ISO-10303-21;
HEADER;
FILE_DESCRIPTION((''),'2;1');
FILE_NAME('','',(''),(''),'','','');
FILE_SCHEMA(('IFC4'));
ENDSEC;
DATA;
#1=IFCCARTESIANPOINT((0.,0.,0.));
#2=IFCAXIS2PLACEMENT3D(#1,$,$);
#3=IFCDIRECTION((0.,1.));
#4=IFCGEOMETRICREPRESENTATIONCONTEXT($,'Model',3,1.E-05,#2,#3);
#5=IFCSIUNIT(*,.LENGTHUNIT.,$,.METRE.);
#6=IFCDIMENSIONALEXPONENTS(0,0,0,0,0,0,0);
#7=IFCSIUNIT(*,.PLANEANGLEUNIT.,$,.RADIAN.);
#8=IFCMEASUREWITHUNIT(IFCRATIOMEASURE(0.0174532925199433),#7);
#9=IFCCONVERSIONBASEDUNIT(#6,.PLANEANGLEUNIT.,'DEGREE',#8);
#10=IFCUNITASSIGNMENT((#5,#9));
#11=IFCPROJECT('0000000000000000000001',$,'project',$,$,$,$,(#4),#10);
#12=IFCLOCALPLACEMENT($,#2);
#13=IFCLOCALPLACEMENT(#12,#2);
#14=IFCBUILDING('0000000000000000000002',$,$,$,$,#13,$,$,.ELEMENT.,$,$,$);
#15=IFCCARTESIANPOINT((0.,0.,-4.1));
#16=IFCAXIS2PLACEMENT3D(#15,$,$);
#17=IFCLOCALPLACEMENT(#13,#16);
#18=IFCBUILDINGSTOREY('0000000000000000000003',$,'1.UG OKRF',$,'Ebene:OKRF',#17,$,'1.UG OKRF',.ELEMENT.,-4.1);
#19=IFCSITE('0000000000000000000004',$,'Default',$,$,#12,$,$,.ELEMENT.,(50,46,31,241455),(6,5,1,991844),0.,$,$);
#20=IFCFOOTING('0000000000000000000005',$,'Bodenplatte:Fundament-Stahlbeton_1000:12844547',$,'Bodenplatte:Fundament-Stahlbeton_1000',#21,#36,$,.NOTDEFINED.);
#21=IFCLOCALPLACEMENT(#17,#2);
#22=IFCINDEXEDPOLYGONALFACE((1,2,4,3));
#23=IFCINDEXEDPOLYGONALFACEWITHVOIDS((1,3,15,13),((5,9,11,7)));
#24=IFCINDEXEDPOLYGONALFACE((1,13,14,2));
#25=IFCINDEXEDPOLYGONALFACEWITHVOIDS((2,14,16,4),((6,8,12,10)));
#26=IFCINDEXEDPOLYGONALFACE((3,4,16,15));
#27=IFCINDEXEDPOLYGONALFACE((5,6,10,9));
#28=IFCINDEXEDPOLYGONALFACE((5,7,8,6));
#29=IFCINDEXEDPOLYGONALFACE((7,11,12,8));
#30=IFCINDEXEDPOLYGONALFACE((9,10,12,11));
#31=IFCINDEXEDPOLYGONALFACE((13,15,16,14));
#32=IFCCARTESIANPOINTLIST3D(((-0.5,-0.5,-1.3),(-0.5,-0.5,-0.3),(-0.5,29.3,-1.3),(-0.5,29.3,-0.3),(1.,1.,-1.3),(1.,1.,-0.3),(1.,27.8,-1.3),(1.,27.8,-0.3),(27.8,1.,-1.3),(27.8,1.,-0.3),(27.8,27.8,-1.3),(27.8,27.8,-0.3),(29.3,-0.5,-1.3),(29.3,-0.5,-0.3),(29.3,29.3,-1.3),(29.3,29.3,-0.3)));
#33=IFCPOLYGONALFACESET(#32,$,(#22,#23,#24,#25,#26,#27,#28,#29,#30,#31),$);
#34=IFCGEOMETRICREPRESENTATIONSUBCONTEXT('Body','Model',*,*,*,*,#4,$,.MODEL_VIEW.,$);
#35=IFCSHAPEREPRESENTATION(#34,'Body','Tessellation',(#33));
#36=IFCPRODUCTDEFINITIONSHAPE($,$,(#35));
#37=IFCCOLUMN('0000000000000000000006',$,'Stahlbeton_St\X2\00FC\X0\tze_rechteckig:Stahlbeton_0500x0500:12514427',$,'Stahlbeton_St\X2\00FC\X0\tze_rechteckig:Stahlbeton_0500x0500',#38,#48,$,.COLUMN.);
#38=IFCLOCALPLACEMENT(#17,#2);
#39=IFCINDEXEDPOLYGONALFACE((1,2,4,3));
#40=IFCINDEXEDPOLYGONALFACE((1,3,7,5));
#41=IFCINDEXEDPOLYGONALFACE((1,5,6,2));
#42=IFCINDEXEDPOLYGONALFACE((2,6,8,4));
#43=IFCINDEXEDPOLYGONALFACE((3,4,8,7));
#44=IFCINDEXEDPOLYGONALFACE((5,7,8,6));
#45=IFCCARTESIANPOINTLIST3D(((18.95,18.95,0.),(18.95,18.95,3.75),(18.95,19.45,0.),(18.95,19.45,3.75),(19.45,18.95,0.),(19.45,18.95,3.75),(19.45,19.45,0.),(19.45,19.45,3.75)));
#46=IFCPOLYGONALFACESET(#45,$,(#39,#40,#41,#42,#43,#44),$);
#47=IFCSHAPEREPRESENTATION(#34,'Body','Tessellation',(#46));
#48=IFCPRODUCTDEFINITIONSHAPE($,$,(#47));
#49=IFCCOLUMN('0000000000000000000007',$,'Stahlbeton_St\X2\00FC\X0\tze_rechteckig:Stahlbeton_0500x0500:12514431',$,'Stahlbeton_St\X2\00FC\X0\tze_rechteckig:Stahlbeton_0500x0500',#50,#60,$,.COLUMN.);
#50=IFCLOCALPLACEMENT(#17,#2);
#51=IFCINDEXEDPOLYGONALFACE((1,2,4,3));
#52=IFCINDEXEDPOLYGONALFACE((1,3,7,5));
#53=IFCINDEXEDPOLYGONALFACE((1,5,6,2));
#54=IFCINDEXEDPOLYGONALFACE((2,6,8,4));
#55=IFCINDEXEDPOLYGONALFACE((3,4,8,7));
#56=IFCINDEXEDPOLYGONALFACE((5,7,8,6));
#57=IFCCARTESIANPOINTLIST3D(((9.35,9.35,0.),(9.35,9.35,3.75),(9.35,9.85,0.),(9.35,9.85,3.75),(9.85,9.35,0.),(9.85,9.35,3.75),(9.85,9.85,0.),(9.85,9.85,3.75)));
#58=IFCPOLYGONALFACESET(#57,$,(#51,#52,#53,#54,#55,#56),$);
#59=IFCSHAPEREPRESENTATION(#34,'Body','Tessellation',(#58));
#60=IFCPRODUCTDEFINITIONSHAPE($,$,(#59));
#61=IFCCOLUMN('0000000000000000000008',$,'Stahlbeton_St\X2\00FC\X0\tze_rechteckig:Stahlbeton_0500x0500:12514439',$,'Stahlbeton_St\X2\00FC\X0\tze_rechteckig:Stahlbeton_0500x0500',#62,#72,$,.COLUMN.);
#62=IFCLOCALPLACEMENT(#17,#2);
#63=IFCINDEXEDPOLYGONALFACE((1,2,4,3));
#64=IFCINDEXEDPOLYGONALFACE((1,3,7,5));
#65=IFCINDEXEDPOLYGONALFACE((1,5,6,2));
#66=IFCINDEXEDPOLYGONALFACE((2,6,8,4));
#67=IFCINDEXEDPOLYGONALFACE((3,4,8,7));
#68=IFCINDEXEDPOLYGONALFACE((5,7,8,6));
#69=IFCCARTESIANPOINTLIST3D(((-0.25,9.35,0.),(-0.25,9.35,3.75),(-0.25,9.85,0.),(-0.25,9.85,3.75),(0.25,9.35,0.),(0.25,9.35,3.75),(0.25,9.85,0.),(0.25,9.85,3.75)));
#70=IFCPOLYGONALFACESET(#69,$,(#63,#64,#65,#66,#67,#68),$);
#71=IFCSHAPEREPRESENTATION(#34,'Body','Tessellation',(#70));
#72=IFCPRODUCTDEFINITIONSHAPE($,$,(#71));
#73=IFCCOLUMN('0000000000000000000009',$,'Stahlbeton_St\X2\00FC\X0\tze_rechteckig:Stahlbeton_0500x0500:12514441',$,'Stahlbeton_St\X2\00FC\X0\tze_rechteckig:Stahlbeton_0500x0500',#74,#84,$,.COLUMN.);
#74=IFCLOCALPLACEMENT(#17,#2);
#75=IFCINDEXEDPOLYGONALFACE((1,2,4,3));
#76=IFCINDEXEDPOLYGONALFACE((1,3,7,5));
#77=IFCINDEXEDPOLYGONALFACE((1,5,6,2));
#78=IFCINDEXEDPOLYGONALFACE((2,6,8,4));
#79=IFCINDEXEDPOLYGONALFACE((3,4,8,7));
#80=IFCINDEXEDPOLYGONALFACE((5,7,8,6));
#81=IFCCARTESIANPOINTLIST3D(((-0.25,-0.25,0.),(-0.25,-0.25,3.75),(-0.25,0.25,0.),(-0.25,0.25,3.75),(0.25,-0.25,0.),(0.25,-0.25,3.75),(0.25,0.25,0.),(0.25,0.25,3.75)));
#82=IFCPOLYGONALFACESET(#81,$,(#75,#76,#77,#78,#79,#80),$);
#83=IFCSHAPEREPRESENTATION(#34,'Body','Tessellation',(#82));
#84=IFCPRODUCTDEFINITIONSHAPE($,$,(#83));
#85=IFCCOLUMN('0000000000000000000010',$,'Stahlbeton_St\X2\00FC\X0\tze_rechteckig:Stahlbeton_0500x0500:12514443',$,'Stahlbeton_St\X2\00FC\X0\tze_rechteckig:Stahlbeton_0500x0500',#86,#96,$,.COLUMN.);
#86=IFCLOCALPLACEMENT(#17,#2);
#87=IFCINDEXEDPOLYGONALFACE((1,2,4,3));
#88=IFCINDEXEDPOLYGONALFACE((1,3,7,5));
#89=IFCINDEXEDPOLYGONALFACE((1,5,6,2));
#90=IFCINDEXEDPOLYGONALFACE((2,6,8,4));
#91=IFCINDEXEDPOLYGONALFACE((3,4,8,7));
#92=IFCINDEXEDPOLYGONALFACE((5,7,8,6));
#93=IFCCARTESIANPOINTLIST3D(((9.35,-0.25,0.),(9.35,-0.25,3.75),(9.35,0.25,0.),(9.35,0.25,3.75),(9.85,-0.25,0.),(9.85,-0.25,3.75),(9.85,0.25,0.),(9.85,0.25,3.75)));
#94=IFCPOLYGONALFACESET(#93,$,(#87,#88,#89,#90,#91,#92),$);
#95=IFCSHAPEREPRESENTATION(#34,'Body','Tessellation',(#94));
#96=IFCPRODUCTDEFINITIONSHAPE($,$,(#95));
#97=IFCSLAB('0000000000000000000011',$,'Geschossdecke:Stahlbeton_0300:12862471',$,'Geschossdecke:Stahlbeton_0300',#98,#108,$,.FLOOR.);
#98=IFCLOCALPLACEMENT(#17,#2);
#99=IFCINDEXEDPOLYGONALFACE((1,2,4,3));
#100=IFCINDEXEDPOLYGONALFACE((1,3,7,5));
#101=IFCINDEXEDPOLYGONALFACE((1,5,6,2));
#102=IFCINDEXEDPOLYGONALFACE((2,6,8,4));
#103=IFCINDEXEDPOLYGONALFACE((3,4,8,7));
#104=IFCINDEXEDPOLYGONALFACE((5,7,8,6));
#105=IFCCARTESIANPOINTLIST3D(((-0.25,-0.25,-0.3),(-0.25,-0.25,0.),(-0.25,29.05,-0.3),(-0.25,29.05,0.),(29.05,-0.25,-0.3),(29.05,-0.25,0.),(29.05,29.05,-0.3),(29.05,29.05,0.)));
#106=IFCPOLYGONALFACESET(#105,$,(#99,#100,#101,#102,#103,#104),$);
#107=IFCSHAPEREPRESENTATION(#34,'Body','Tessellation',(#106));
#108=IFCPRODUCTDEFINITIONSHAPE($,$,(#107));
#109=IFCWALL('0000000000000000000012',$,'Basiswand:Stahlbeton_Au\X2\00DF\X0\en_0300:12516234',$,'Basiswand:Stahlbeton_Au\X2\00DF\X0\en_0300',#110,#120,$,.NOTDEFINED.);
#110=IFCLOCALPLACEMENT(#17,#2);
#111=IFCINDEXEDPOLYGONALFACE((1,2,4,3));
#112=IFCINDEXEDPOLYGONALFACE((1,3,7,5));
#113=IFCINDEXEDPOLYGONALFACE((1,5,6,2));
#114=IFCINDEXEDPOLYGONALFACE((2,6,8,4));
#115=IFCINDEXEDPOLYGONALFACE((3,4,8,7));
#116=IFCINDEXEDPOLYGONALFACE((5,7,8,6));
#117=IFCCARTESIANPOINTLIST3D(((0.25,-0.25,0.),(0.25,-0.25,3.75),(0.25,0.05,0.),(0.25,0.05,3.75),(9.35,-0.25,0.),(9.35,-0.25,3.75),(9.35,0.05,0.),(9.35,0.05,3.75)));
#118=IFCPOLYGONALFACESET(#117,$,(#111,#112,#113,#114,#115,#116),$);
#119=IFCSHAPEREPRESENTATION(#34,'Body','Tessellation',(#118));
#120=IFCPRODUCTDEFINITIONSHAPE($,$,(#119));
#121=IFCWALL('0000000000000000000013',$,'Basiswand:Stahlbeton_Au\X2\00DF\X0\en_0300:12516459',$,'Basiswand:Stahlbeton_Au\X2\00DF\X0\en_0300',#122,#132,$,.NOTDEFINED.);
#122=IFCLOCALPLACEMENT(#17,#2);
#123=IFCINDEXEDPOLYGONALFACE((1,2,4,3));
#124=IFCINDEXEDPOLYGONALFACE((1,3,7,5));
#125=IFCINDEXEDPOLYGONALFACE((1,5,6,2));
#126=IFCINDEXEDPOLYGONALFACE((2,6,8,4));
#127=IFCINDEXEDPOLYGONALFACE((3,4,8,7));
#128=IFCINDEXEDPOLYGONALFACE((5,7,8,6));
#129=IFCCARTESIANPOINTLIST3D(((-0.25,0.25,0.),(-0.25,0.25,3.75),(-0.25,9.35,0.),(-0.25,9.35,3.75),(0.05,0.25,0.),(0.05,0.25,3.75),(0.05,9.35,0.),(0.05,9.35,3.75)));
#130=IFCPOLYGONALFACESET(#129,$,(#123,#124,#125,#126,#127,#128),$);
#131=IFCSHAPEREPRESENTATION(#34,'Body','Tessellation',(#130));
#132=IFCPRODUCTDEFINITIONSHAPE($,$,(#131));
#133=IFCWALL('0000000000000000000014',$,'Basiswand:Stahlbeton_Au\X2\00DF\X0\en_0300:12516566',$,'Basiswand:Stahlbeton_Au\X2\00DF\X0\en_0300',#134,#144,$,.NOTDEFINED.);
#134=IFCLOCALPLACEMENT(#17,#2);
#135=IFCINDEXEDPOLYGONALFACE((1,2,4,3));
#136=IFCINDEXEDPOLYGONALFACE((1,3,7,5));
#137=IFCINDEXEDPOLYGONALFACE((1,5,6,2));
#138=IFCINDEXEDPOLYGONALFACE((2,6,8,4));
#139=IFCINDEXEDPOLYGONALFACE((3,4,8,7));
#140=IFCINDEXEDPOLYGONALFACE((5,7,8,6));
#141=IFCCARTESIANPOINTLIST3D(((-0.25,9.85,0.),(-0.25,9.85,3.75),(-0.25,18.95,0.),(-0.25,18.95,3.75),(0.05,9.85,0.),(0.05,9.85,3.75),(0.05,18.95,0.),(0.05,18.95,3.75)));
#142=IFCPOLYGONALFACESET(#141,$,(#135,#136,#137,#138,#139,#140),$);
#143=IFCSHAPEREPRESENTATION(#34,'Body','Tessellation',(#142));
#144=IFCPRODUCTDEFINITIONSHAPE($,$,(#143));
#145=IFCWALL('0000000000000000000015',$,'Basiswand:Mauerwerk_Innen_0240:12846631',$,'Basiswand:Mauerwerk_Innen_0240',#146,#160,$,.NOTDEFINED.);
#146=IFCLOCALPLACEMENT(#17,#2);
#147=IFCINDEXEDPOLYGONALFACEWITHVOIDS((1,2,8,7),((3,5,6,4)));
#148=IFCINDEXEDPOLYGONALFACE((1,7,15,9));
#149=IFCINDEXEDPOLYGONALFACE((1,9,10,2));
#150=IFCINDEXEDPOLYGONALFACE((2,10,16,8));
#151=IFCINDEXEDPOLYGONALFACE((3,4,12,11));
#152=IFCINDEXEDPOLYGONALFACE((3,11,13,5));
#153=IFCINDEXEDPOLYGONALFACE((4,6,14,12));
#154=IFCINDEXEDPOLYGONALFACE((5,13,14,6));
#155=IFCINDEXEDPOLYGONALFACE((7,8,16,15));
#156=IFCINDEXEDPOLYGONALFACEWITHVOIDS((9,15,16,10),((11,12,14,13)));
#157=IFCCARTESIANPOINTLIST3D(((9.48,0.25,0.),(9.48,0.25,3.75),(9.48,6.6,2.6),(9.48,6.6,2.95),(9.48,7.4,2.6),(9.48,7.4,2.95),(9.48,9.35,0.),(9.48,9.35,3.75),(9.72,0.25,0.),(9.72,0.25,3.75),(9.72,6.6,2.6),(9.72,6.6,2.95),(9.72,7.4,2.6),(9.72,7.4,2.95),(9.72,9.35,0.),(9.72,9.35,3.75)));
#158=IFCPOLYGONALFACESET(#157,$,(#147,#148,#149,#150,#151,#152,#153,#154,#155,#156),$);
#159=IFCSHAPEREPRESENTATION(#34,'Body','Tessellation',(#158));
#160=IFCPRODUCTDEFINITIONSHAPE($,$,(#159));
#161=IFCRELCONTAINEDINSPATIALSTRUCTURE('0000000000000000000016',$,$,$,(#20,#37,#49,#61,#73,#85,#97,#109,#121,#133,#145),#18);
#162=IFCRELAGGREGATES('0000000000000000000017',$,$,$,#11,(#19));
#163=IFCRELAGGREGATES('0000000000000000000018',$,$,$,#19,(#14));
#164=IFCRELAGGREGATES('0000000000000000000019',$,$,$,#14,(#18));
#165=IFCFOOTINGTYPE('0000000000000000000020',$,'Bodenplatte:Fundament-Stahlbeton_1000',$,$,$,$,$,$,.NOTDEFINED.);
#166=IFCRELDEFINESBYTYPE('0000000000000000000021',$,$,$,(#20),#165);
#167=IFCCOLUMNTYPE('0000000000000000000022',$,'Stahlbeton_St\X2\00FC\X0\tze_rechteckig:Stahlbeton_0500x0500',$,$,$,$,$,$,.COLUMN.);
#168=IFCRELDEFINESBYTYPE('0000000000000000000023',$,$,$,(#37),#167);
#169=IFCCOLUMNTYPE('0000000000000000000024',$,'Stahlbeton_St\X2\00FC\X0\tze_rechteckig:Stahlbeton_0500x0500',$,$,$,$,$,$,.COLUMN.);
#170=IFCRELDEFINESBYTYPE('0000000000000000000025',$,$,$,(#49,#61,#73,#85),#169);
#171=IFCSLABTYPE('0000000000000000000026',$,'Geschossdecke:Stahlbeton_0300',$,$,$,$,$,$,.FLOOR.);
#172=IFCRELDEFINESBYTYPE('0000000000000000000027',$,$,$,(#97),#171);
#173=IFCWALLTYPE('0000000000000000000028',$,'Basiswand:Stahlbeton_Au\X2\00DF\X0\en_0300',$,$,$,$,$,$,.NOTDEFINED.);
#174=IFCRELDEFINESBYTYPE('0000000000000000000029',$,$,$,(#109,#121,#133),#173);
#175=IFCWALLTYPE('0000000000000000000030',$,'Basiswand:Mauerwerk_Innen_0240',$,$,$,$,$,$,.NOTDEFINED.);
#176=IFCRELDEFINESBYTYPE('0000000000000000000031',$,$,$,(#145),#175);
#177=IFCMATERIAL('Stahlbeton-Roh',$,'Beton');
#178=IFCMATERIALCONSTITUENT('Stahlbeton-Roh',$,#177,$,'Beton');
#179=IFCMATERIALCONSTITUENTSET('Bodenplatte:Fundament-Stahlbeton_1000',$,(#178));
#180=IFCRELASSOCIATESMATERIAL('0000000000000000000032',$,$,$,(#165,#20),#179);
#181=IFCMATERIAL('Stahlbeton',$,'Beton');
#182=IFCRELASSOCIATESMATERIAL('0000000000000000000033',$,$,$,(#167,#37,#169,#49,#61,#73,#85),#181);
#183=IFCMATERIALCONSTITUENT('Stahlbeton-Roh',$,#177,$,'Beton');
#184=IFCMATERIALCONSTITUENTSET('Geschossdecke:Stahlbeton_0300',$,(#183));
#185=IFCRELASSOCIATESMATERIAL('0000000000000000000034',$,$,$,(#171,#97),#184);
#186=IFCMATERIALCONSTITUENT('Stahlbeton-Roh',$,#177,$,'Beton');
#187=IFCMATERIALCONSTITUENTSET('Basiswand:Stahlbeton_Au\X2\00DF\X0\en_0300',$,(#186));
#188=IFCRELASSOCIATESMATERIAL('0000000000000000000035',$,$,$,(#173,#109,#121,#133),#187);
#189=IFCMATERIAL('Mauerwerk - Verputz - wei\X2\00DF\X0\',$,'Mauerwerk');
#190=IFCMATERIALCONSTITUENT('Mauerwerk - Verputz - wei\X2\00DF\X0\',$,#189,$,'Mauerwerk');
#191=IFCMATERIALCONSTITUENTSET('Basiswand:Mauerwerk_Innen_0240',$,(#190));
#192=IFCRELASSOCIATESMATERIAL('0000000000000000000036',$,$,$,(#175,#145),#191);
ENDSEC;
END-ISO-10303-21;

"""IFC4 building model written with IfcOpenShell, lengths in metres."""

from ifc_helpers import new_model, entity, si_unit, converted_unit, direction, frame, origin, place, context, subcontext, project, spatial, indexed_curve, outline, extrude, source, transform, mapped, material, constituent, constituent_set, type_object, type_shapes, element, save


model = new_model("IFC4")

# Units and contexts
model_context = context("Model", 3, precision=1e-05, world=origin(), true_north=direction((0.0, 1.0)))
body_context = subcontext(model_context, "Body", "Model", "MODEL_VIEW")
ifc_project = project(units=[si_unit("LENGTHUNIT", "METRE"), converted_unit("PLANEANGLEUNIT", "DEGREE", entity("IfcRatioMeasure", 0.0174532925199433), si_unit("PLANEANGLEUNIT", "RADIAN"), dimensions=[0, 0, 0, 0, 0, 0, 0])], contexts=[model_context])

# Site, building, storey
site_placement = place(None, origin())
site = spatial("IfcSite", under=ifc_project, at=site_placement, Name="Default", CompositionType="ELEMENT", RefLatitude=(50, 46, 31, 241455), RefLongitude=(6, 5, 1, 991844), RefElevation=0.0)
building_placement = place(site_placement, origin())
building = spatial("IfcBuilding", under=site, at=building_placement, CompositionType="ELEMENT")
storey_placement = place(building_placement, frame((0.0, 0.0, -4.1)))
storey = spatial("IfcBuildingStorey", under=building, at=storey_placement, Name="1.UG OKRF", ObjectType="Ebene:OKRF", LongName="1.UG OKRF", CompositionType="ELEMENT", Elevation=-4.1)

# Footing
ifc_material_1 = material(Name="Stahlbeton-Roh", Category="Beton")
ifc_constituent_1 = constituent(ifc_material_1, Name="Stahlbeton-Roh", Category="Beton")
ifc_constituent_set_1 = constituent_set(constituents=[ifc_constituent_1], Name="Bodenplatte:Fundament-Stahlbeton_1000")
footing_type = type_object("IfcFootingType", Name="Bodenplatte:Fundament-Stahlbeton_1000", PredefinedType="NOTDEFINED", material=ifc_constituent_set_1)
footing_placement = place(storey_placement, origin())
element("IfcFooting", 1, at=footing_placement, inside=storey, type_object=footing_type, material=ifc_constituent_set_1, Name="Bodenplatte:Fundament-Stahlbeton_1000:12844547", ObjectType="Bodenplatte:Fundament-Stahlbeton_1000", PredefinedType="NOTDEFINED", context=body_context, shape_type="SweptSolid", body=[
    extrude(outline(indexed_curve([(-14.9, -14.9), (14.9, -14.9), (14.9, 14.9), (-14.9, 14.9), (-14.9, -14.9)], self_intersect=False), holes=[indexed_curve([(-13.4, -13.4), (-13.4, 13.4), (13.4, 13.4), (13.4, -13.4), (-13.4, -13.4)], self_intersect=False)]), frame((14.4, 14.4, -1.3)), (0.0, 0.0, 1.0), 1.0),
])

# Columns
ifc_material_2 = material(Name="Stahlbeton", Category="Beton")
column_type_1 = type_object("IfcColumnType", Name="Stahlbeton_Stütze_rechteckig:Stahlbeton_0500x0500", PredefinedType="COLUMN", material=ifc_material_2)
shared_shape_1 = source(origin(), body_context, "Body", "SweptSolid", [
    extrude(outline(indexed_curve([(-0.25, -0.25), (0.25, -0.25), (0.25, 0.25), (-0.25, 0.25), (-0.25, -0.25)], self_intersect=False)), frame((19.2, 19.2, -4.1), z_axis=(0.0, 0.0, 1.0), x_axis=(0.0, -1.0, 0.0)), (0.0, 0.0, 1.0), 3.75),
])
type_shapes(column_type_1, [shared_shape_1])
column_placement = place(storey_placement, frame((0.0, 0.0, 4.1)))
element("IfcColumn", 2, at=column_placement, inside=storey, type_object=column_type_1, material=ifc_material_2, Name="Stahlbeton_Stütze_rechteckig:Stahlbeton_0500x0500:12514427", ObjectType="Stahlbeton_Stütze_rechteckig:Stahlbeton_0500x0500", PredefinedType="COLUMN", context=body_context, shape_type="MappedRepresentation", body=[
    mapped(shared_shape_1, transform((0.0, 0.0, 0.0), scale=1.0)),
])
column_type_2 = type_object("IfcColumnType", Name="Stahlbeton_Stütze_rechteckig:Stahlbeton_0500x0500", PredefinedType="COLUMN", material=ifc_material_2)
shared_shape_2 = source(origin(), body_context, "Body", "SweptSolid", [
    extrude(outline(indexed_curve([(-0.25, -0.25), (0.25, -0.25), (0.25, 0.25), (-0.25, 0.25), (-0.25, -0.25)], self_intersect=False)), frame((0.0, 0.0, -4.1), z_axis=(0.0, 0.0, 1.0), x_axis=(0.0, -1.0, 0.0)), (0.0, 0.0, 1.0), 3.75),
])
type_shapes(column_type_2, [shared_shape_2])
for number, where, name in (
    (3, (9.6, 9.6, 4.1), "Stahlbeton_Stütze_rechteckig:Stahlbeton_0500x0500:12514431"),
    (4, (0.0, 9.6, 4.1), "Stahlbeton_Stütze_rechteckig:Stahlbeton_0500x0500:12514439"),
    (5, (0.0, 0.0, 4.1), "Stahlbeton_Stütze_rechteckig:Stahlbeton_0500x0500:12514441"),
    (6, (9.6, 0.0, 4.1), "Stahlbeton_Stütze_rechteckig:Stahlbeton_0500x0500:12514443"),
):
    element("IfcColumn", number, at=place(storey_placement, frame(where)), inside=storey, type_object=column_type_2, material=ifc_material_2, Name=name, ObjectType="Stahlbeton_Stütze_rechteckig:Stahlbeton_0500x0500", PredefinedType="COLUMN", context=body_context, shape_type="MappedRepresentation", body=[
        mapped(shared_shape_2, transform((0.0, 0.0, 0.0), scale=1.0)),
    ])

# Slab
ifc_constituent_2 = constituent(ifc_material_1, Name="Stahlbeton-Roh", Category="Beton")
ifc_constituent_set_2 = constituent_set(constituents=[ifc_constituent_2], Name="Geschossdecke:Stahlbeton_0300")
slab_type = type_object("IfcSlabType", Name="Geschossdecke:Stahlbeton_0300", PredefinedType="FLOOR", material=ifc_constituent_set_2)
slab_placement = place(storey_placement, origin())
element("IfcSlab", 7, at=slab_placement, inside=storey, type_object=slab_type, material=ifc_constituent_set_2, Name="Geschossdecke:Stahlbeton_0300:12862471", ObjectType="Geschossdecke:Stahlbeton_0300", PredefinedType="FLOOR", context=body_context, shape_type="SweptSolid", body=[
    extrude(outline(indexed_curve([(-14.65, -14.65), (14.65, -14.65), (14.65, 14.65), (-14.65, 14.65), (-14.65, -14.65)], self_intersect=False)), frame((14.4, 14.4, -0.3), z_axis=(0.0, 0.0, 1.0), x_axis=(-1.0, 0.0, 0.0)), (0.0, 0.0, 1.0), 0.3),
])

# Walls
ifc_constituent_3 = constituent(ifc_material_1, Name="Stahlbeton-Roh", Category="Beton")
ifc_constituent_set_3 = constituent_set(constituents=[ifc_constituent_3], Name="Basiswand:Stahlbeton_Außen_0300")
wall_type_1 = type_object("IfcWallType", Name="Basiswand:Stahlbeton_Außen_0300", PredefinedType="NOTDEFINED", material=ifc_constituent_set_3)
wall_1_placement = place(storey_placement, frame((9.35, -0.1, 0.0), z_axis=(0.0, 0.0, 1.0), x_axis=(-1.0, 0.0, 0.0)))
element("IfcWall", 8, at=wall_1_placement, inside=storey, type_object=wall_type_1, material=ifc_constituent_set_3, Name="Basiswand:Stahlbeton_Außen_0300:12516234", ObjectType="Basiswand:Stahlbeton_Außen_0300", PredefinedType="NOTDEFINED", context=body_context, shape_type="SweptSolid", body=[
    extrude(outline(indexed_curve([(-0.15, -4.55), (0.15, -4.55), (0.15, 4.55), (-0.15, 4.55), (-0.15, -4.55)], self_intersect=False)), frame((4.55, 0.0, 0.0), z_axis=(0.0, 0.0, 1.0), x_axis=(0.0, 1.0, 0.0)), (0.0, 0.0, 1.0), 3.75),
])
for number, where, z_axis, x_axis, name in (
    (9, (-0.1, 0.25, 0.0), (0.0, 0.0, 1.0), (0.0, 1.0, 0.0), "Basiswand:Stahlbeton_Außen_0300:12516459"),
    (10, (-0.1, 9.85, 0.0), (0.0, 0.0, 1.0), (0.0, 1.0, 0.0), "Basiswand:Stahlbeton_Außen_0300:12516566"),
):
    element("IfcWall", number, at=place(storey_placement, frame(where, z_axis=z_axis, x_axis=x_axis)), inside=storey, type_object=wall_type_1, material=ifc_constituent_set_3, Name=name, ObjectType="Basiswand:Stahlbeton_Außen_0300", PredefinedType="NOTDEFINED", context=body_context, shape_type="SweptSolid", body=[
        extrude(outline(indexed_curve([(-0.15, -4.55), (0.15, -4.55), (0.15, 4.55), (-0.15, 4.55), (-0.15, -4.55)], self_intersect=False)), frame((4.55, 0.0, 0.0), z_axis=(0.0, 0.0, 1.0), x_axis=(0.0, 1.0, 0.0)), (0.0, 0.0, 1.0), 3.75),
    ])

# Wall, opening
ifc_material_3 = material(Name="Mauerwerk - Verputz - weiß", Category="Mauerwerk")
ifc_constituent_4 = constituent(ifc_material_3, Name="Mauerwerk - Verputz - weiß", Category="Mauerwerk")
ifc_constituent_set_4 = constituent_set(constituents=[ifc_constituent_4], Name="Basiswand:Mauerwerk_Innen_0240")
wall_type_2 = type_object("IfcWallType", Name="Basiswand:Mauerwerk_Innen_0240", PredefinedType="NOTDEFINED", material=ifc_constituent_set_4)
wall_2_placement = place(storey_placement, frame((9.6, 9.35, 0.0), z_axis=(0.0, 0.0, 1.0), x_axis=(0.0, -1.0, 0.0)))
wall_2 = element("IfcWall", 11, at=wall_2_placement, inside=storey, type_object=wall_type_2, material=ifc_constituent_set_4, Name="Basiswand:Mauerwerk_Innen_0240:12846631", ObjectType="Basiswand:Mauerwerk_Innen_0240", PredefinedType="NOTDEFINED", context=body_context, shape_type="SweptSolid", body=[
    extrude(outline(indexed_curve([(-1.875, -4.55), (1.875, -4.55), (1.875, 4.55), (-1.875, 4.55), (-1.875, -4.55)], self_intersect=False), holes=[indexed_curve([(1.075, -2.6), (0.725, -2.6), (0.725, -1.8), (1.075, -1.8), (1.075, -2.6)], self_intersect=False)]), frame((4.55, -0.12, 1.875), z_axis=(0.0, 1.0, 0.0), x_axis=(0.0, 0.0, 1.0)), (0.0, 0.0, 1.0), 0.24),
])
opening_1_placement = place(wall_2_placement, origin())
element("IfcOpeningElement", 12, at=opening_1_placement, cuts=wall_2, ObjectType="Opening", PredefinedType="OPENING", context=body_context, shape_type="SweptSolid", body=[
    extrude(outline(indexed_curve([(-0.175, -0.4), (0.175, -0.4), (0.175, 0.4), (-0.175, 0.4), (-0.175, -0.4)], self_intersect=False)), frame((2.35, -0.12, 2.775), z_axis=(0.0, 1.0, 0.0), x_axis=(0.0, 0.0, -1.0)), (0.0, 0.0, 1.0), 0.24),
])

save(model, "model.ifc")
